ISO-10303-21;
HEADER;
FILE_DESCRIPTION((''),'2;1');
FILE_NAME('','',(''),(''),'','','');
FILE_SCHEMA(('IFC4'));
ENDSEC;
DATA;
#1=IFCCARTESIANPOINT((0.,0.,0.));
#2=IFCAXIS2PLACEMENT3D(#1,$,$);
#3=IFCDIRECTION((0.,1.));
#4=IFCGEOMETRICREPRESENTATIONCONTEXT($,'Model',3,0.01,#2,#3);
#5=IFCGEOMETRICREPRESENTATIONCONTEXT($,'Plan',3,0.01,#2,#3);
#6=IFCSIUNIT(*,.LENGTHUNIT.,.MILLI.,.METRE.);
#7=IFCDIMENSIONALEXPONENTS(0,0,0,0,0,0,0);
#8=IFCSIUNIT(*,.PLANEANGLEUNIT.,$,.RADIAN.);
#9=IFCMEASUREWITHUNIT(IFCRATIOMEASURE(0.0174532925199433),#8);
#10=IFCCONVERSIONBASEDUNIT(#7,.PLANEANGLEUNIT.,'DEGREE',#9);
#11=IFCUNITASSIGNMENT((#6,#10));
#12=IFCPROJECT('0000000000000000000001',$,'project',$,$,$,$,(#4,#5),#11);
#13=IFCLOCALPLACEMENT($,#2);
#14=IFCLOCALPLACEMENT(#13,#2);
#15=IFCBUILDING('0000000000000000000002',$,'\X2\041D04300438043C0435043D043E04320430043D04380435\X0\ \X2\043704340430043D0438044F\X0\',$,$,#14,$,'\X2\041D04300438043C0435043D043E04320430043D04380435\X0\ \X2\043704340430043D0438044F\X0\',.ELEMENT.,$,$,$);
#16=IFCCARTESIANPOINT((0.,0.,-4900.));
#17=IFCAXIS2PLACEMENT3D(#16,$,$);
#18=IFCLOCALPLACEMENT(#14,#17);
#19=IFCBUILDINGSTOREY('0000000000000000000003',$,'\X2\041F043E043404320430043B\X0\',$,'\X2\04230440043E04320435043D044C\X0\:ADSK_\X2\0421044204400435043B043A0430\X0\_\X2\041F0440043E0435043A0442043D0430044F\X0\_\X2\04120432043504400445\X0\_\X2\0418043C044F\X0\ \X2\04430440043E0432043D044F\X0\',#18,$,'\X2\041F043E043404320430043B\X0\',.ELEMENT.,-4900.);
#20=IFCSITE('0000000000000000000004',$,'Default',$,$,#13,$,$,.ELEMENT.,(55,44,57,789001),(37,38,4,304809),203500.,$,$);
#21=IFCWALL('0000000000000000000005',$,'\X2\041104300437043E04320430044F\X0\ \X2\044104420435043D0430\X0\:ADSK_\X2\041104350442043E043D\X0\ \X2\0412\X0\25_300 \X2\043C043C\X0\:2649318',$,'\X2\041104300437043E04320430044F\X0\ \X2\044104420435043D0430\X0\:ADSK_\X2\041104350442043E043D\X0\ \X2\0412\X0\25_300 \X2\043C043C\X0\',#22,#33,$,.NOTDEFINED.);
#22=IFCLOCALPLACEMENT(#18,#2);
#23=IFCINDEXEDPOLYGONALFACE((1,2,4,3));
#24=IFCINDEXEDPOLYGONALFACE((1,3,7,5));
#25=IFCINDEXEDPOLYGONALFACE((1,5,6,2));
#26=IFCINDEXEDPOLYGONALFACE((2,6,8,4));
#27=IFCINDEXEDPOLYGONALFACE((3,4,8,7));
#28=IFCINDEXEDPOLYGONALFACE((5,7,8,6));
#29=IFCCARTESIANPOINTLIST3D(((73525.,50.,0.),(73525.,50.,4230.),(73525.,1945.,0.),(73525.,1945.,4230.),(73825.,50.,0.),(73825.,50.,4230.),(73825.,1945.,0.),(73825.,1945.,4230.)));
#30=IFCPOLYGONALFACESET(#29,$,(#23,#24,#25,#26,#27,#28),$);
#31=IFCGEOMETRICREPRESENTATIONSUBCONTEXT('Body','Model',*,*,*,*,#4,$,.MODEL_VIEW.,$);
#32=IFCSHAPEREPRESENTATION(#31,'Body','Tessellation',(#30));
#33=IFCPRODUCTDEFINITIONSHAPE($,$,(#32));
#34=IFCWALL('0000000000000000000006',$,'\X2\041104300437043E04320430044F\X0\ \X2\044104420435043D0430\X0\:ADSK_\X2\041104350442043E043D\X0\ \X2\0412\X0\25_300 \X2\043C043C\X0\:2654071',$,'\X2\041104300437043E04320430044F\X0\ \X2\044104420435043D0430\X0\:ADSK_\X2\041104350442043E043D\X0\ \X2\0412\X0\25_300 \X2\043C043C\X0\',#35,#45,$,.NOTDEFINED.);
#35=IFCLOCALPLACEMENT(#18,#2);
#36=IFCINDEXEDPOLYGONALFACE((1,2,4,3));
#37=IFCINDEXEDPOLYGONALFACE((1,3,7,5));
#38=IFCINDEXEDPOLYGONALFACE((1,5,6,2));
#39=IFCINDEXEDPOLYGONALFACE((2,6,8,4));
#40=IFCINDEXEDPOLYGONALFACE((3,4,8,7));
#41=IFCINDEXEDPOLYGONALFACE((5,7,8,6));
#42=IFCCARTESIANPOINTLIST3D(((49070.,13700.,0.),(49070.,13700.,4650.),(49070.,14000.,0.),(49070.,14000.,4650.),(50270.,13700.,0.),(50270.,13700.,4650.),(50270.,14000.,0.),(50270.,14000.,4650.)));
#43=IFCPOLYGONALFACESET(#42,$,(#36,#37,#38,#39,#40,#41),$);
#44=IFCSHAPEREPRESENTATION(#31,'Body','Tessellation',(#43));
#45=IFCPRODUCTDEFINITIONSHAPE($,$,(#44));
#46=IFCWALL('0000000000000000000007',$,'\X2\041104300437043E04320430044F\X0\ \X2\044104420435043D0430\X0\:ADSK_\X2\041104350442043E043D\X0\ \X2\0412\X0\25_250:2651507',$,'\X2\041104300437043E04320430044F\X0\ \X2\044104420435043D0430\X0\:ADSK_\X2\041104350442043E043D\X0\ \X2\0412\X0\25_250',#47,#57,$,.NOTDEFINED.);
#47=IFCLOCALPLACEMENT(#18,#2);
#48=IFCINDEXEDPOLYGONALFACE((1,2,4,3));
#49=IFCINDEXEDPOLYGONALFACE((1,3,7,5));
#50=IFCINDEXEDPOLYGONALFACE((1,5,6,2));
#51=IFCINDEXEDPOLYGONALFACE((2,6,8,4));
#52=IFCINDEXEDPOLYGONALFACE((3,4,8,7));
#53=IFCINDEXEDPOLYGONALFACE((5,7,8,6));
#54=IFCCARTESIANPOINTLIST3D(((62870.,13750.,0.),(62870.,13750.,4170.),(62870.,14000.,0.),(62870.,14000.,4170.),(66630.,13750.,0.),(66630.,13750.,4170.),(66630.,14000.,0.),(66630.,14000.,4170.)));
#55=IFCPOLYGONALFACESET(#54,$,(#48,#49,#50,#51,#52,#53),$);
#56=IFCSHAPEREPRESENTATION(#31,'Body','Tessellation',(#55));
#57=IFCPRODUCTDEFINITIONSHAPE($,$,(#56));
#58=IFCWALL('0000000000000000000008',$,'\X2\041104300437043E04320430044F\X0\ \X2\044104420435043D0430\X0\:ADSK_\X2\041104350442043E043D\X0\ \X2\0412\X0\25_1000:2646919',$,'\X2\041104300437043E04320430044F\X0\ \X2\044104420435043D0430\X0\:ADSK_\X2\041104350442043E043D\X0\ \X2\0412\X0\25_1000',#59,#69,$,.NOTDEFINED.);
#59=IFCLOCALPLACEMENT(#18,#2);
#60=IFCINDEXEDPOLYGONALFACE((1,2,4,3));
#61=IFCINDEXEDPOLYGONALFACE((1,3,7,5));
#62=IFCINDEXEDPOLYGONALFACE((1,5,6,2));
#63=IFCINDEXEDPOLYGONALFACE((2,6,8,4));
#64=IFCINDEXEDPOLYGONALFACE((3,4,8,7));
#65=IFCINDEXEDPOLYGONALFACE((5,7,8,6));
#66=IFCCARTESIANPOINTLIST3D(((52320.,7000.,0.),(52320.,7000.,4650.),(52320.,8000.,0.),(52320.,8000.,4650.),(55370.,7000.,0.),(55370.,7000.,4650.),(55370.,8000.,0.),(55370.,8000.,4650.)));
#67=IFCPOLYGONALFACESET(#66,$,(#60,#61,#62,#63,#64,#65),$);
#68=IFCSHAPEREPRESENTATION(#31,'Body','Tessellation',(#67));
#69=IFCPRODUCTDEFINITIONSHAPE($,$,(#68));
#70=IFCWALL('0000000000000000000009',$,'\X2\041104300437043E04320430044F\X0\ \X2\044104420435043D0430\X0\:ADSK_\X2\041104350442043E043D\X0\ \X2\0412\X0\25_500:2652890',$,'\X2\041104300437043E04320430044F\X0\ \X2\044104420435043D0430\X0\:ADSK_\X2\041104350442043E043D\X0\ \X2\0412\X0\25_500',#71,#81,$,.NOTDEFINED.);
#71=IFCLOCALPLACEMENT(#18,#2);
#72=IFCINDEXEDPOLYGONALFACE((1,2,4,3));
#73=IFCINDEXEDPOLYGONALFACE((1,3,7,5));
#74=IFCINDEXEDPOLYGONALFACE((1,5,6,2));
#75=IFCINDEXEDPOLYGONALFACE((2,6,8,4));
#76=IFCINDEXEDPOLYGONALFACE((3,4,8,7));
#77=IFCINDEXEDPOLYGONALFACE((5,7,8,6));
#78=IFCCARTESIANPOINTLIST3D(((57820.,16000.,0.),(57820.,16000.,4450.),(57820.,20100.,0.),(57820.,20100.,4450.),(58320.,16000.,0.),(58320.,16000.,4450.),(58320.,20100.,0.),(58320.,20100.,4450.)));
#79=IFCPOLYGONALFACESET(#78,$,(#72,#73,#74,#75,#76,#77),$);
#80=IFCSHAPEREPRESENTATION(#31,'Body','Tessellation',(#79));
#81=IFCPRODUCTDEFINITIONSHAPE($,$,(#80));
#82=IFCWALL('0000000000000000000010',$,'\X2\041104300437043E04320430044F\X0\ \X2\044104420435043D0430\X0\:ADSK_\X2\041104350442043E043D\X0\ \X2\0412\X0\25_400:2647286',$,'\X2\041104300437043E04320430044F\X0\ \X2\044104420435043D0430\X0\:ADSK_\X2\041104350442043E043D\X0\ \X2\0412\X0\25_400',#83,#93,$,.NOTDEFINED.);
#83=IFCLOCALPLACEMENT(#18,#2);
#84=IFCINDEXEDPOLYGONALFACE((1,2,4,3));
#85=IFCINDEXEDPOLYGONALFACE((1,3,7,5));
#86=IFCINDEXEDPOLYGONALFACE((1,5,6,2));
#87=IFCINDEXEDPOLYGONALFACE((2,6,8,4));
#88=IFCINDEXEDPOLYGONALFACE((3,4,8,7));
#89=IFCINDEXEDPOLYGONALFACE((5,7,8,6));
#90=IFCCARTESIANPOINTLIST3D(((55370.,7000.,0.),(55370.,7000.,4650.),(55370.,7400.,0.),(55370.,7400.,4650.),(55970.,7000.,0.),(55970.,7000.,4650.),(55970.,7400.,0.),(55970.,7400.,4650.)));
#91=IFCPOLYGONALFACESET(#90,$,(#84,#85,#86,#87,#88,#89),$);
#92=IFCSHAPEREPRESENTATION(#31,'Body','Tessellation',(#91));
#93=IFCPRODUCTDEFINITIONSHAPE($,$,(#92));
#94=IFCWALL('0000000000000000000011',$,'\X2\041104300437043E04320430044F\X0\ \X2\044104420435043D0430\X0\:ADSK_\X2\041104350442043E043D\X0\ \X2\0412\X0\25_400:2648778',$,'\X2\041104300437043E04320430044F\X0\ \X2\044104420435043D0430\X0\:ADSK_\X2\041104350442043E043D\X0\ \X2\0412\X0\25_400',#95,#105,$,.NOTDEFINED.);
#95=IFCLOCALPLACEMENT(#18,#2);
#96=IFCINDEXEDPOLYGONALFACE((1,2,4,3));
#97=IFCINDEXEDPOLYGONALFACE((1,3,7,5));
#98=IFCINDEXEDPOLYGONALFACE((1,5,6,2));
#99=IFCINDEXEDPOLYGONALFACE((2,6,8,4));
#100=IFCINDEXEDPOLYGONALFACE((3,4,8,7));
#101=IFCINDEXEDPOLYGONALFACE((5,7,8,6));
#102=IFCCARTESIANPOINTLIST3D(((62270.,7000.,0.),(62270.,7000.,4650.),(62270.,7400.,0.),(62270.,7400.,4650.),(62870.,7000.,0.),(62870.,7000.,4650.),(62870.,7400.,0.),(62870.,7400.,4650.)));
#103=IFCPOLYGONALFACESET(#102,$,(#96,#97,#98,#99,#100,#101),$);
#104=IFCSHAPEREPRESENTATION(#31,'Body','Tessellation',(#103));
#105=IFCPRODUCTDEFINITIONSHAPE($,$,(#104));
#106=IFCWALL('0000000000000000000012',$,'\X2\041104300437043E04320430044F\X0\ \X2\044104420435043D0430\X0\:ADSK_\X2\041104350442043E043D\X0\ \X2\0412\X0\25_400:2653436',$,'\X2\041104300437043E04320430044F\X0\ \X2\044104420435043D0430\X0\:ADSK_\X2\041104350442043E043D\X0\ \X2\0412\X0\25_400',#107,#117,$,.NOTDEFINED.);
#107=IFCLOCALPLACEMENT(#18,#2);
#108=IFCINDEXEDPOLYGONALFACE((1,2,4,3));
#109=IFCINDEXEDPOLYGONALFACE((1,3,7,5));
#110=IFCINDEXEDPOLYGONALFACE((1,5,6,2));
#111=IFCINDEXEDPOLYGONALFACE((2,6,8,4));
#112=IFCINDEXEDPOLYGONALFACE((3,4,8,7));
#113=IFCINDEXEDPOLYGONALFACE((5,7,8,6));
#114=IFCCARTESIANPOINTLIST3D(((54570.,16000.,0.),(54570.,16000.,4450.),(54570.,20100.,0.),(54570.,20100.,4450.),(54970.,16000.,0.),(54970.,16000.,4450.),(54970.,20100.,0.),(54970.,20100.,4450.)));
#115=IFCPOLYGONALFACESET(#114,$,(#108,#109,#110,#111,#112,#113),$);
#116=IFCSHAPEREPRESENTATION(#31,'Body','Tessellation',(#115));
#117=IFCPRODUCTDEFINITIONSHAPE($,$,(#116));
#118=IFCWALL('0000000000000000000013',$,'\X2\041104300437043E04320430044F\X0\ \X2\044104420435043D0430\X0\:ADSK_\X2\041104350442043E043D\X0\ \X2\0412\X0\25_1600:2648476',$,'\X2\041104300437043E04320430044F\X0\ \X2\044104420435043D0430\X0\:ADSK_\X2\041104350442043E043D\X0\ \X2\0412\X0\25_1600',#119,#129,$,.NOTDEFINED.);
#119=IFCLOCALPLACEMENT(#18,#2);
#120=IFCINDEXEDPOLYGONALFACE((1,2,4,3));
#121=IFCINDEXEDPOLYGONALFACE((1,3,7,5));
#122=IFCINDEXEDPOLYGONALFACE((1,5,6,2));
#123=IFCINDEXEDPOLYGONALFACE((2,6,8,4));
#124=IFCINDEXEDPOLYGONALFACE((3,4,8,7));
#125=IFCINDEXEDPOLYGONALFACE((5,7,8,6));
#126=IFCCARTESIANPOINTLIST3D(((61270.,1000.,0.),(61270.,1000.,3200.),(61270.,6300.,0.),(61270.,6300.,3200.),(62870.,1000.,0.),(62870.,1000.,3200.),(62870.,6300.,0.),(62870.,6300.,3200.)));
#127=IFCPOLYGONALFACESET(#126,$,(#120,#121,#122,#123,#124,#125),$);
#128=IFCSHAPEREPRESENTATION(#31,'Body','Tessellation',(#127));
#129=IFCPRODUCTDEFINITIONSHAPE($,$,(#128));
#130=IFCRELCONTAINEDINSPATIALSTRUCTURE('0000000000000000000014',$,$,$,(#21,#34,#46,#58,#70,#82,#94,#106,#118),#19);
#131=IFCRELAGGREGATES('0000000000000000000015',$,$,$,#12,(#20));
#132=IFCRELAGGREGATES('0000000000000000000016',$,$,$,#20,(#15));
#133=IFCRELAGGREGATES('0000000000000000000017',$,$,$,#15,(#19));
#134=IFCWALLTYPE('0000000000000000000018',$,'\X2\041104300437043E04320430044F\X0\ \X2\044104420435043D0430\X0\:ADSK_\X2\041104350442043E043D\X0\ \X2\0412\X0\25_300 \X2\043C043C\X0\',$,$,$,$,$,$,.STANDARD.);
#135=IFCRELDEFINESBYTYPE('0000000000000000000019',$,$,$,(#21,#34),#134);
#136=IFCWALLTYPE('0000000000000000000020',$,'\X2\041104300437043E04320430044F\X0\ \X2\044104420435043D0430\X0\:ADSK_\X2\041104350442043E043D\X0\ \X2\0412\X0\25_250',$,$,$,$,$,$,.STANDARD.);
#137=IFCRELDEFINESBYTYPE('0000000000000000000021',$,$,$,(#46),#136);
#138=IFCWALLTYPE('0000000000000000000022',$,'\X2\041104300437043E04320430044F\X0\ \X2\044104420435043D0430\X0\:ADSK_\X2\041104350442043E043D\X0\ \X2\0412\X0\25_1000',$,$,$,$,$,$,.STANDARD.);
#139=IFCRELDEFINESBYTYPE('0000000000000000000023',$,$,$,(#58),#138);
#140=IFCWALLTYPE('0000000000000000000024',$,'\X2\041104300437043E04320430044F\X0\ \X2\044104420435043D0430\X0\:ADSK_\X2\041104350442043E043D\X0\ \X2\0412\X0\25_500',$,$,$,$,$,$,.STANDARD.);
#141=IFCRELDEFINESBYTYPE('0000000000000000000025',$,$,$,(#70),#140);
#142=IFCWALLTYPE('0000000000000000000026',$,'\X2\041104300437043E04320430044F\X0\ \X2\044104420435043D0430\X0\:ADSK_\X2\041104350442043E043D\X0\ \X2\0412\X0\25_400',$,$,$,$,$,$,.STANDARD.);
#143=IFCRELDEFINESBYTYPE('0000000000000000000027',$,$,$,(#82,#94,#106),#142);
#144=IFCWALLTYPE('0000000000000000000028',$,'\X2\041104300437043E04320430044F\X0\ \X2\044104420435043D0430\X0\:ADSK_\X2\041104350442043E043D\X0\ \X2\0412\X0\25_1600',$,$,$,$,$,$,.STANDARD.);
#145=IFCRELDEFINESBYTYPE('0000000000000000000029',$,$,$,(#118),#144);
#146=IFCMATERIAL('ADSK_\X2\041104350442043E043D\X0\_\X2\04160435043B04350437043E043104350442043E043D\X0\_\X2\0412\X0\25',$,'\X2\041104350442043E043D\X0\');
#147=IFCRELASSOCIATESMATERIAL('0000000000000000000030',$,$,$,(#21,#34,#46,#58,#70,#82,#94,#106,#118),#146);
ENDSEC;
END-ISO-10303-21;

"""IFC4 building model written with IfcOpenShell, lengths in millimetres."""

from ifc_helpers import new_model, entity, si_unit, converted_unit, direction, frame, origin, place, context, subcontext, project, spatial, indexed_curve, outline, extrude, material, type_object, element, save


model = new_model("IFC4")

# Units and contexts
model_context = context("Model", 3, precision=0.01, world=origin(), true_north=direction((0.0, 1.0)))
plan_context = context("Plan", 3, precision=0.01, world=origin(), true_north=direction((0.0, 1.0)))
body_context = subcontext(model_context, "Body", "Model", "MODEL_VIEW")
ifc_project = project(units=[si_unit("LENGTHUNIT", "METRE", prefix="MILLI"), converted_unit("PLANEANGLEUNIT", "DEGREE", entity("IfcRatioMeasure", 0.0174532925199433), si_unit("PLANEANGLEUNIT", "RADIAN"), dimensions=[0, 0, 0, 0, 0, 0, 0])], contexts=[model_context, plan_context])

# Site, building, storey
site_placement = place(None, origin())
site = spatial("IfcSite", under=ifc_project, at=site_placement, Name="Default", CompositionType="ELEMENT", RefLatitude=(55, 44, 57, 789001), RefLongitude=(37, 38, 4, 304809), RefElevation=203500.0)
building_placement = place(site_placement, origin())
building = spatial("IfcBuilding", under=site, at=building_placement, Name="Наименование здания", LongName="Наименование здания", CompositionType="ELEMENT")
storey_placement = place(building_placement, frame((0.0, 0.0, -4900.0)))
storey = spatial("IfcBuildingStorey", under=building, at=storey_placement, Name="Подвал", ObjectType="Уровень:ADSK_Стрелка_Проектная_Вверх_Имя уровня", LongName="Подвал", CompositionType="ELEMENT", Elevation=-4900.0)

# Shared definitions
ifc_material = material(Name="ADSK_Бетон_Железобетон_В25", Category="Бетон")

# Walls
wall_type_1 = type_object("IfcWallType", Name="Базовая стена:ADSK_Бетон В25_300 мм", PredefinedType="STANDARD")
wall_1_placement = place(storey_placement, frame((73675.0, 1945.0, 0.0), z_axis=(0.0, 0.0, 1.0), x_axis=(0.0, -1.0, 0.0)))
element("IfcWall", 1, at=wall_1_placement, inside=storey, type_object=wall_type_1, material=ifc_material, Name="Базовая стена:ADSK_Бетон В25_300 мм:2649318", ObjectType="Базовая стена:ADSK_Бетон В25_300 мм", PredefinedType="NOTDEFINED", context=body_context, shape_type="SweptSolid", body=[
    extrude(outline(indexed_curve([(1895.0, 150.0), (0.0, 150.0), (0.0, -150.0), (1895.0, -150.0), (1895.0, 150.0)], self_intersect=False)), origin(), (0.0, 0.0, 1.0), 4230.0),
])
wall_2_placement = place(storey_placement, frame((49070.0, 13850.0, 0.0)))
element("IfcWall", 2, at=wall_2_placement, inside=storey, type_object=wall_type_1, material=ifc_material, Name="Базовая стена:ADSK_Бетон В25_300 мм:2654071", ObjectType="Базовая стена:ADSK_Бетон В25_300 мм", PredefinedType="NOTDEFINED", context=body_context, shape_type="SweptSolid", body=[
    extrude(outline(indexed_curve([(1200.0, 150.0), (0.0, 150.0), (0.0, -150.0), (1200.0, -150.0), (1200.0, 150.0)], self_intersect=False)), origin(), (0.0, 0.0, 1.0), 4650.0),
])
wall_type_2 = type_object("IfcWallType", Name="Базовая стена:ADSK_Бетон В25_250", PredefinedType="STANDARD")
wall_3_placement = place(storey_placement, frame((62870.0, 13875.0, 0.0)))
element("IfcWall", 3, at=wall_3_placement, inside=storey, type_object=wall_type_2, material=ifc_material, Name="Базовая стена:ADSK_Бетон В25_250:2651507", ObjectType="Базовая стена:ADSK_Бетон В25_250", PredefinedType="NOTDEFINED", context=body_context, shape_type="SweptSolid", body=[
    extrude(outline(indexed_curve([(3760.0, 125.0), (0.0, 125.0), (0.0, -125.0), (3760.0, -125.0), (3760.0, 125.0)], self_intersect=False)), origin(), (0.0, 0.0, 1.0), 4170.0),
])
wall_type_3 = type_object("IfcWallType", Name="Базовая стена:ADSK_Бетон В25_1000", PredefinedType="STANDARD")
wall_4_placement = place(storey_placement, frame((52320.0, 7500.0, 0.0)))
element("IfcWall", 4, at=wall_4_placement, inside=storey, type_object=wall_type_3, material=ifc_material, Name="Базовая стена:ADSK_Бетон В25_1000:2646919", ObjectType="Базовая стена:ADSK_Бетон В25_1000", PredefinedType="NOTDEFINED", context=body_context, shape_type="SweptSolid", body=[
    extrude(outline(indexed_curve([(3050.0, 500.0), (0.0, 500.0), (0.0, -500.0), (3050.0, -500.0), (3050.0, 500.0)], self_intersect=False)), origin(), (0.0, 0.0, 1.0), 4650.0),
])
wall_type_4 = type_object("IfcWallType", Name="Базовая стена:ADSK_Бетон В25_500", PredefinedType="STANDARD")
wall_5_placement = place(storey_placement, frame((58070.0, 20100.0, 0.0), z_axis=(0.0, 0.0, 1.0), x_axis=(0.0, -1.0, 0.0)))
element("IfcWall", 5, at=wall_5_placement, inside=storey, type_object=wall_type_4, material=ifc_material, Name="Базовая стена:ADSK_Бетон В25_500:2652890", ObjectType="Базовая стена:ADSK_Бетон В25_500", PredefinedType="NOTDEFINED", context=body_context, shape_type="SweptSolid", body=[
    extrude(outline(indexed_curve([(4100.0, 250.0), (0.0, 250.0), (0.0, -250.0), (4100.0, -250.0), (4100.0, 250.0)], self_intersect=False)), origin(), (0.0, 0.0, 1.0), 4450.0),
])
wall_type_5 = type_object("IfcWallType", Name="Базовая стена:ADSK_Бетон В25_400", PredefinedType="STANDARD")
wall_6_placement = place(storey_placement, frame((55370.0, 7200.0, 0.0)))
element("IfcWall", 6, at=wall_6_placement, inside=storey, type_object=wall_type_5, material=ifc_material, Name="Базовая стена:ADSK_Бетон В25_400:2647286", ObjectType="Базовая стена:ADSK_Бетон В25_400", PredefinedType="NOTDEFINED", context=body_context, shape_type="SweptSolid", body=[
    extrude(outline(indexed_curve([(600.0, 200.0), (0.0, 200.0), (0.0, -200.0), (600.0, -200.0), (600.0, 200.0)], self_intersect=False)), origin(), (0.0, 0.0, 1.0), 4650.0),
])
wall_7_placement = place(storey_placement, frame((62270.0, 7200.0, 0.0)))
element("IfcWall", 7, at=wall_7_placement, inside=storey, type_object=wall_type_5, material=ifc_material, Name="Базовая стена:ADSK_Бетон В25_400:2648778", ObjectType="Базовая стена:ADSK_Бетон В25_400", PredefinedType="NOTDEFINED", context=body_context, shape_type="SweptSolid", body=[
    extrude(outline(indexed_curve([(600.0, 200.0), (0.0, 200.0), (0.0, -200.0), (600.0, -200.0), (600.0, 200.0)], self_intersect=False)), origin(), (0.0, 0.0, 1.0), 4650.0),
])
wall_8_placement = place(storey_placement, frame((54770.0, 20100.0, 0.0), z_axis=(0.0, 0.0, 1.0), x_axis=(0.0, -1.0, 0.0)))
element("IfcWall", 8, at=wall_8_placement, inside=storey, type_object=wall_type_5, material=ifc_material, Name="Базовая стена:ADSK_Бетон В25_400:2653436", ObjectType="Базовая стена:ADSK_Бетон В25_400", PredefinedType="NOTDEFINED", context=body_context, shape_type="SweptSolid", body=[
    extrude(outline(indexed_curve([(4100.0, 200.0), (0.0, 200.0), (0.0, -200.0), (4100.0, -200.0), (4100.0, 200.0)], self_intersect=False)), origin(), (0.0, 0.0, 1.0), 4450.0),
])
wall_type_6 = type_object("IfcWallType", Name="Базовая стена:ADSK_Бетон В25_1600", PredefinedType="STANDARD")
wall_9_placement = place(storey_placement, frame((62070.0, 1000.0, 0.0), z_axis=(0.0, 0.0, 1.0), x_axis=(0.0, 1.0, 0.0)))
element("IfcWall", 9, at=wall_9_placement, inside=storey, type_object=wall_type_6, material=ifc_material, Name="Базовая стена:ADSK_Бетон В25_1600:2648476", ObjectType="Базовая стена:ADSK_Бетон В25_1600", PredefinedType="NOTDEFINED", context=body_context, shape_type="SweptSolid", body=[
    extrude(outline(indexed_curve([(-800.0, -2650.0), (800.0, -2650.0), (800.0, 2650.0), (-800.0, 2650.0), (-800.0, -2650.0)], self_intersect=False)), frame((2650.0, 0.0, 0.0), z_axis=(0.0, 0.0, 1.0), x_axis=(0.0, 1.0, 0.0)), (0.0, 0.0, 1.0), 3200.0),
])

save(model, "model.ifc")
